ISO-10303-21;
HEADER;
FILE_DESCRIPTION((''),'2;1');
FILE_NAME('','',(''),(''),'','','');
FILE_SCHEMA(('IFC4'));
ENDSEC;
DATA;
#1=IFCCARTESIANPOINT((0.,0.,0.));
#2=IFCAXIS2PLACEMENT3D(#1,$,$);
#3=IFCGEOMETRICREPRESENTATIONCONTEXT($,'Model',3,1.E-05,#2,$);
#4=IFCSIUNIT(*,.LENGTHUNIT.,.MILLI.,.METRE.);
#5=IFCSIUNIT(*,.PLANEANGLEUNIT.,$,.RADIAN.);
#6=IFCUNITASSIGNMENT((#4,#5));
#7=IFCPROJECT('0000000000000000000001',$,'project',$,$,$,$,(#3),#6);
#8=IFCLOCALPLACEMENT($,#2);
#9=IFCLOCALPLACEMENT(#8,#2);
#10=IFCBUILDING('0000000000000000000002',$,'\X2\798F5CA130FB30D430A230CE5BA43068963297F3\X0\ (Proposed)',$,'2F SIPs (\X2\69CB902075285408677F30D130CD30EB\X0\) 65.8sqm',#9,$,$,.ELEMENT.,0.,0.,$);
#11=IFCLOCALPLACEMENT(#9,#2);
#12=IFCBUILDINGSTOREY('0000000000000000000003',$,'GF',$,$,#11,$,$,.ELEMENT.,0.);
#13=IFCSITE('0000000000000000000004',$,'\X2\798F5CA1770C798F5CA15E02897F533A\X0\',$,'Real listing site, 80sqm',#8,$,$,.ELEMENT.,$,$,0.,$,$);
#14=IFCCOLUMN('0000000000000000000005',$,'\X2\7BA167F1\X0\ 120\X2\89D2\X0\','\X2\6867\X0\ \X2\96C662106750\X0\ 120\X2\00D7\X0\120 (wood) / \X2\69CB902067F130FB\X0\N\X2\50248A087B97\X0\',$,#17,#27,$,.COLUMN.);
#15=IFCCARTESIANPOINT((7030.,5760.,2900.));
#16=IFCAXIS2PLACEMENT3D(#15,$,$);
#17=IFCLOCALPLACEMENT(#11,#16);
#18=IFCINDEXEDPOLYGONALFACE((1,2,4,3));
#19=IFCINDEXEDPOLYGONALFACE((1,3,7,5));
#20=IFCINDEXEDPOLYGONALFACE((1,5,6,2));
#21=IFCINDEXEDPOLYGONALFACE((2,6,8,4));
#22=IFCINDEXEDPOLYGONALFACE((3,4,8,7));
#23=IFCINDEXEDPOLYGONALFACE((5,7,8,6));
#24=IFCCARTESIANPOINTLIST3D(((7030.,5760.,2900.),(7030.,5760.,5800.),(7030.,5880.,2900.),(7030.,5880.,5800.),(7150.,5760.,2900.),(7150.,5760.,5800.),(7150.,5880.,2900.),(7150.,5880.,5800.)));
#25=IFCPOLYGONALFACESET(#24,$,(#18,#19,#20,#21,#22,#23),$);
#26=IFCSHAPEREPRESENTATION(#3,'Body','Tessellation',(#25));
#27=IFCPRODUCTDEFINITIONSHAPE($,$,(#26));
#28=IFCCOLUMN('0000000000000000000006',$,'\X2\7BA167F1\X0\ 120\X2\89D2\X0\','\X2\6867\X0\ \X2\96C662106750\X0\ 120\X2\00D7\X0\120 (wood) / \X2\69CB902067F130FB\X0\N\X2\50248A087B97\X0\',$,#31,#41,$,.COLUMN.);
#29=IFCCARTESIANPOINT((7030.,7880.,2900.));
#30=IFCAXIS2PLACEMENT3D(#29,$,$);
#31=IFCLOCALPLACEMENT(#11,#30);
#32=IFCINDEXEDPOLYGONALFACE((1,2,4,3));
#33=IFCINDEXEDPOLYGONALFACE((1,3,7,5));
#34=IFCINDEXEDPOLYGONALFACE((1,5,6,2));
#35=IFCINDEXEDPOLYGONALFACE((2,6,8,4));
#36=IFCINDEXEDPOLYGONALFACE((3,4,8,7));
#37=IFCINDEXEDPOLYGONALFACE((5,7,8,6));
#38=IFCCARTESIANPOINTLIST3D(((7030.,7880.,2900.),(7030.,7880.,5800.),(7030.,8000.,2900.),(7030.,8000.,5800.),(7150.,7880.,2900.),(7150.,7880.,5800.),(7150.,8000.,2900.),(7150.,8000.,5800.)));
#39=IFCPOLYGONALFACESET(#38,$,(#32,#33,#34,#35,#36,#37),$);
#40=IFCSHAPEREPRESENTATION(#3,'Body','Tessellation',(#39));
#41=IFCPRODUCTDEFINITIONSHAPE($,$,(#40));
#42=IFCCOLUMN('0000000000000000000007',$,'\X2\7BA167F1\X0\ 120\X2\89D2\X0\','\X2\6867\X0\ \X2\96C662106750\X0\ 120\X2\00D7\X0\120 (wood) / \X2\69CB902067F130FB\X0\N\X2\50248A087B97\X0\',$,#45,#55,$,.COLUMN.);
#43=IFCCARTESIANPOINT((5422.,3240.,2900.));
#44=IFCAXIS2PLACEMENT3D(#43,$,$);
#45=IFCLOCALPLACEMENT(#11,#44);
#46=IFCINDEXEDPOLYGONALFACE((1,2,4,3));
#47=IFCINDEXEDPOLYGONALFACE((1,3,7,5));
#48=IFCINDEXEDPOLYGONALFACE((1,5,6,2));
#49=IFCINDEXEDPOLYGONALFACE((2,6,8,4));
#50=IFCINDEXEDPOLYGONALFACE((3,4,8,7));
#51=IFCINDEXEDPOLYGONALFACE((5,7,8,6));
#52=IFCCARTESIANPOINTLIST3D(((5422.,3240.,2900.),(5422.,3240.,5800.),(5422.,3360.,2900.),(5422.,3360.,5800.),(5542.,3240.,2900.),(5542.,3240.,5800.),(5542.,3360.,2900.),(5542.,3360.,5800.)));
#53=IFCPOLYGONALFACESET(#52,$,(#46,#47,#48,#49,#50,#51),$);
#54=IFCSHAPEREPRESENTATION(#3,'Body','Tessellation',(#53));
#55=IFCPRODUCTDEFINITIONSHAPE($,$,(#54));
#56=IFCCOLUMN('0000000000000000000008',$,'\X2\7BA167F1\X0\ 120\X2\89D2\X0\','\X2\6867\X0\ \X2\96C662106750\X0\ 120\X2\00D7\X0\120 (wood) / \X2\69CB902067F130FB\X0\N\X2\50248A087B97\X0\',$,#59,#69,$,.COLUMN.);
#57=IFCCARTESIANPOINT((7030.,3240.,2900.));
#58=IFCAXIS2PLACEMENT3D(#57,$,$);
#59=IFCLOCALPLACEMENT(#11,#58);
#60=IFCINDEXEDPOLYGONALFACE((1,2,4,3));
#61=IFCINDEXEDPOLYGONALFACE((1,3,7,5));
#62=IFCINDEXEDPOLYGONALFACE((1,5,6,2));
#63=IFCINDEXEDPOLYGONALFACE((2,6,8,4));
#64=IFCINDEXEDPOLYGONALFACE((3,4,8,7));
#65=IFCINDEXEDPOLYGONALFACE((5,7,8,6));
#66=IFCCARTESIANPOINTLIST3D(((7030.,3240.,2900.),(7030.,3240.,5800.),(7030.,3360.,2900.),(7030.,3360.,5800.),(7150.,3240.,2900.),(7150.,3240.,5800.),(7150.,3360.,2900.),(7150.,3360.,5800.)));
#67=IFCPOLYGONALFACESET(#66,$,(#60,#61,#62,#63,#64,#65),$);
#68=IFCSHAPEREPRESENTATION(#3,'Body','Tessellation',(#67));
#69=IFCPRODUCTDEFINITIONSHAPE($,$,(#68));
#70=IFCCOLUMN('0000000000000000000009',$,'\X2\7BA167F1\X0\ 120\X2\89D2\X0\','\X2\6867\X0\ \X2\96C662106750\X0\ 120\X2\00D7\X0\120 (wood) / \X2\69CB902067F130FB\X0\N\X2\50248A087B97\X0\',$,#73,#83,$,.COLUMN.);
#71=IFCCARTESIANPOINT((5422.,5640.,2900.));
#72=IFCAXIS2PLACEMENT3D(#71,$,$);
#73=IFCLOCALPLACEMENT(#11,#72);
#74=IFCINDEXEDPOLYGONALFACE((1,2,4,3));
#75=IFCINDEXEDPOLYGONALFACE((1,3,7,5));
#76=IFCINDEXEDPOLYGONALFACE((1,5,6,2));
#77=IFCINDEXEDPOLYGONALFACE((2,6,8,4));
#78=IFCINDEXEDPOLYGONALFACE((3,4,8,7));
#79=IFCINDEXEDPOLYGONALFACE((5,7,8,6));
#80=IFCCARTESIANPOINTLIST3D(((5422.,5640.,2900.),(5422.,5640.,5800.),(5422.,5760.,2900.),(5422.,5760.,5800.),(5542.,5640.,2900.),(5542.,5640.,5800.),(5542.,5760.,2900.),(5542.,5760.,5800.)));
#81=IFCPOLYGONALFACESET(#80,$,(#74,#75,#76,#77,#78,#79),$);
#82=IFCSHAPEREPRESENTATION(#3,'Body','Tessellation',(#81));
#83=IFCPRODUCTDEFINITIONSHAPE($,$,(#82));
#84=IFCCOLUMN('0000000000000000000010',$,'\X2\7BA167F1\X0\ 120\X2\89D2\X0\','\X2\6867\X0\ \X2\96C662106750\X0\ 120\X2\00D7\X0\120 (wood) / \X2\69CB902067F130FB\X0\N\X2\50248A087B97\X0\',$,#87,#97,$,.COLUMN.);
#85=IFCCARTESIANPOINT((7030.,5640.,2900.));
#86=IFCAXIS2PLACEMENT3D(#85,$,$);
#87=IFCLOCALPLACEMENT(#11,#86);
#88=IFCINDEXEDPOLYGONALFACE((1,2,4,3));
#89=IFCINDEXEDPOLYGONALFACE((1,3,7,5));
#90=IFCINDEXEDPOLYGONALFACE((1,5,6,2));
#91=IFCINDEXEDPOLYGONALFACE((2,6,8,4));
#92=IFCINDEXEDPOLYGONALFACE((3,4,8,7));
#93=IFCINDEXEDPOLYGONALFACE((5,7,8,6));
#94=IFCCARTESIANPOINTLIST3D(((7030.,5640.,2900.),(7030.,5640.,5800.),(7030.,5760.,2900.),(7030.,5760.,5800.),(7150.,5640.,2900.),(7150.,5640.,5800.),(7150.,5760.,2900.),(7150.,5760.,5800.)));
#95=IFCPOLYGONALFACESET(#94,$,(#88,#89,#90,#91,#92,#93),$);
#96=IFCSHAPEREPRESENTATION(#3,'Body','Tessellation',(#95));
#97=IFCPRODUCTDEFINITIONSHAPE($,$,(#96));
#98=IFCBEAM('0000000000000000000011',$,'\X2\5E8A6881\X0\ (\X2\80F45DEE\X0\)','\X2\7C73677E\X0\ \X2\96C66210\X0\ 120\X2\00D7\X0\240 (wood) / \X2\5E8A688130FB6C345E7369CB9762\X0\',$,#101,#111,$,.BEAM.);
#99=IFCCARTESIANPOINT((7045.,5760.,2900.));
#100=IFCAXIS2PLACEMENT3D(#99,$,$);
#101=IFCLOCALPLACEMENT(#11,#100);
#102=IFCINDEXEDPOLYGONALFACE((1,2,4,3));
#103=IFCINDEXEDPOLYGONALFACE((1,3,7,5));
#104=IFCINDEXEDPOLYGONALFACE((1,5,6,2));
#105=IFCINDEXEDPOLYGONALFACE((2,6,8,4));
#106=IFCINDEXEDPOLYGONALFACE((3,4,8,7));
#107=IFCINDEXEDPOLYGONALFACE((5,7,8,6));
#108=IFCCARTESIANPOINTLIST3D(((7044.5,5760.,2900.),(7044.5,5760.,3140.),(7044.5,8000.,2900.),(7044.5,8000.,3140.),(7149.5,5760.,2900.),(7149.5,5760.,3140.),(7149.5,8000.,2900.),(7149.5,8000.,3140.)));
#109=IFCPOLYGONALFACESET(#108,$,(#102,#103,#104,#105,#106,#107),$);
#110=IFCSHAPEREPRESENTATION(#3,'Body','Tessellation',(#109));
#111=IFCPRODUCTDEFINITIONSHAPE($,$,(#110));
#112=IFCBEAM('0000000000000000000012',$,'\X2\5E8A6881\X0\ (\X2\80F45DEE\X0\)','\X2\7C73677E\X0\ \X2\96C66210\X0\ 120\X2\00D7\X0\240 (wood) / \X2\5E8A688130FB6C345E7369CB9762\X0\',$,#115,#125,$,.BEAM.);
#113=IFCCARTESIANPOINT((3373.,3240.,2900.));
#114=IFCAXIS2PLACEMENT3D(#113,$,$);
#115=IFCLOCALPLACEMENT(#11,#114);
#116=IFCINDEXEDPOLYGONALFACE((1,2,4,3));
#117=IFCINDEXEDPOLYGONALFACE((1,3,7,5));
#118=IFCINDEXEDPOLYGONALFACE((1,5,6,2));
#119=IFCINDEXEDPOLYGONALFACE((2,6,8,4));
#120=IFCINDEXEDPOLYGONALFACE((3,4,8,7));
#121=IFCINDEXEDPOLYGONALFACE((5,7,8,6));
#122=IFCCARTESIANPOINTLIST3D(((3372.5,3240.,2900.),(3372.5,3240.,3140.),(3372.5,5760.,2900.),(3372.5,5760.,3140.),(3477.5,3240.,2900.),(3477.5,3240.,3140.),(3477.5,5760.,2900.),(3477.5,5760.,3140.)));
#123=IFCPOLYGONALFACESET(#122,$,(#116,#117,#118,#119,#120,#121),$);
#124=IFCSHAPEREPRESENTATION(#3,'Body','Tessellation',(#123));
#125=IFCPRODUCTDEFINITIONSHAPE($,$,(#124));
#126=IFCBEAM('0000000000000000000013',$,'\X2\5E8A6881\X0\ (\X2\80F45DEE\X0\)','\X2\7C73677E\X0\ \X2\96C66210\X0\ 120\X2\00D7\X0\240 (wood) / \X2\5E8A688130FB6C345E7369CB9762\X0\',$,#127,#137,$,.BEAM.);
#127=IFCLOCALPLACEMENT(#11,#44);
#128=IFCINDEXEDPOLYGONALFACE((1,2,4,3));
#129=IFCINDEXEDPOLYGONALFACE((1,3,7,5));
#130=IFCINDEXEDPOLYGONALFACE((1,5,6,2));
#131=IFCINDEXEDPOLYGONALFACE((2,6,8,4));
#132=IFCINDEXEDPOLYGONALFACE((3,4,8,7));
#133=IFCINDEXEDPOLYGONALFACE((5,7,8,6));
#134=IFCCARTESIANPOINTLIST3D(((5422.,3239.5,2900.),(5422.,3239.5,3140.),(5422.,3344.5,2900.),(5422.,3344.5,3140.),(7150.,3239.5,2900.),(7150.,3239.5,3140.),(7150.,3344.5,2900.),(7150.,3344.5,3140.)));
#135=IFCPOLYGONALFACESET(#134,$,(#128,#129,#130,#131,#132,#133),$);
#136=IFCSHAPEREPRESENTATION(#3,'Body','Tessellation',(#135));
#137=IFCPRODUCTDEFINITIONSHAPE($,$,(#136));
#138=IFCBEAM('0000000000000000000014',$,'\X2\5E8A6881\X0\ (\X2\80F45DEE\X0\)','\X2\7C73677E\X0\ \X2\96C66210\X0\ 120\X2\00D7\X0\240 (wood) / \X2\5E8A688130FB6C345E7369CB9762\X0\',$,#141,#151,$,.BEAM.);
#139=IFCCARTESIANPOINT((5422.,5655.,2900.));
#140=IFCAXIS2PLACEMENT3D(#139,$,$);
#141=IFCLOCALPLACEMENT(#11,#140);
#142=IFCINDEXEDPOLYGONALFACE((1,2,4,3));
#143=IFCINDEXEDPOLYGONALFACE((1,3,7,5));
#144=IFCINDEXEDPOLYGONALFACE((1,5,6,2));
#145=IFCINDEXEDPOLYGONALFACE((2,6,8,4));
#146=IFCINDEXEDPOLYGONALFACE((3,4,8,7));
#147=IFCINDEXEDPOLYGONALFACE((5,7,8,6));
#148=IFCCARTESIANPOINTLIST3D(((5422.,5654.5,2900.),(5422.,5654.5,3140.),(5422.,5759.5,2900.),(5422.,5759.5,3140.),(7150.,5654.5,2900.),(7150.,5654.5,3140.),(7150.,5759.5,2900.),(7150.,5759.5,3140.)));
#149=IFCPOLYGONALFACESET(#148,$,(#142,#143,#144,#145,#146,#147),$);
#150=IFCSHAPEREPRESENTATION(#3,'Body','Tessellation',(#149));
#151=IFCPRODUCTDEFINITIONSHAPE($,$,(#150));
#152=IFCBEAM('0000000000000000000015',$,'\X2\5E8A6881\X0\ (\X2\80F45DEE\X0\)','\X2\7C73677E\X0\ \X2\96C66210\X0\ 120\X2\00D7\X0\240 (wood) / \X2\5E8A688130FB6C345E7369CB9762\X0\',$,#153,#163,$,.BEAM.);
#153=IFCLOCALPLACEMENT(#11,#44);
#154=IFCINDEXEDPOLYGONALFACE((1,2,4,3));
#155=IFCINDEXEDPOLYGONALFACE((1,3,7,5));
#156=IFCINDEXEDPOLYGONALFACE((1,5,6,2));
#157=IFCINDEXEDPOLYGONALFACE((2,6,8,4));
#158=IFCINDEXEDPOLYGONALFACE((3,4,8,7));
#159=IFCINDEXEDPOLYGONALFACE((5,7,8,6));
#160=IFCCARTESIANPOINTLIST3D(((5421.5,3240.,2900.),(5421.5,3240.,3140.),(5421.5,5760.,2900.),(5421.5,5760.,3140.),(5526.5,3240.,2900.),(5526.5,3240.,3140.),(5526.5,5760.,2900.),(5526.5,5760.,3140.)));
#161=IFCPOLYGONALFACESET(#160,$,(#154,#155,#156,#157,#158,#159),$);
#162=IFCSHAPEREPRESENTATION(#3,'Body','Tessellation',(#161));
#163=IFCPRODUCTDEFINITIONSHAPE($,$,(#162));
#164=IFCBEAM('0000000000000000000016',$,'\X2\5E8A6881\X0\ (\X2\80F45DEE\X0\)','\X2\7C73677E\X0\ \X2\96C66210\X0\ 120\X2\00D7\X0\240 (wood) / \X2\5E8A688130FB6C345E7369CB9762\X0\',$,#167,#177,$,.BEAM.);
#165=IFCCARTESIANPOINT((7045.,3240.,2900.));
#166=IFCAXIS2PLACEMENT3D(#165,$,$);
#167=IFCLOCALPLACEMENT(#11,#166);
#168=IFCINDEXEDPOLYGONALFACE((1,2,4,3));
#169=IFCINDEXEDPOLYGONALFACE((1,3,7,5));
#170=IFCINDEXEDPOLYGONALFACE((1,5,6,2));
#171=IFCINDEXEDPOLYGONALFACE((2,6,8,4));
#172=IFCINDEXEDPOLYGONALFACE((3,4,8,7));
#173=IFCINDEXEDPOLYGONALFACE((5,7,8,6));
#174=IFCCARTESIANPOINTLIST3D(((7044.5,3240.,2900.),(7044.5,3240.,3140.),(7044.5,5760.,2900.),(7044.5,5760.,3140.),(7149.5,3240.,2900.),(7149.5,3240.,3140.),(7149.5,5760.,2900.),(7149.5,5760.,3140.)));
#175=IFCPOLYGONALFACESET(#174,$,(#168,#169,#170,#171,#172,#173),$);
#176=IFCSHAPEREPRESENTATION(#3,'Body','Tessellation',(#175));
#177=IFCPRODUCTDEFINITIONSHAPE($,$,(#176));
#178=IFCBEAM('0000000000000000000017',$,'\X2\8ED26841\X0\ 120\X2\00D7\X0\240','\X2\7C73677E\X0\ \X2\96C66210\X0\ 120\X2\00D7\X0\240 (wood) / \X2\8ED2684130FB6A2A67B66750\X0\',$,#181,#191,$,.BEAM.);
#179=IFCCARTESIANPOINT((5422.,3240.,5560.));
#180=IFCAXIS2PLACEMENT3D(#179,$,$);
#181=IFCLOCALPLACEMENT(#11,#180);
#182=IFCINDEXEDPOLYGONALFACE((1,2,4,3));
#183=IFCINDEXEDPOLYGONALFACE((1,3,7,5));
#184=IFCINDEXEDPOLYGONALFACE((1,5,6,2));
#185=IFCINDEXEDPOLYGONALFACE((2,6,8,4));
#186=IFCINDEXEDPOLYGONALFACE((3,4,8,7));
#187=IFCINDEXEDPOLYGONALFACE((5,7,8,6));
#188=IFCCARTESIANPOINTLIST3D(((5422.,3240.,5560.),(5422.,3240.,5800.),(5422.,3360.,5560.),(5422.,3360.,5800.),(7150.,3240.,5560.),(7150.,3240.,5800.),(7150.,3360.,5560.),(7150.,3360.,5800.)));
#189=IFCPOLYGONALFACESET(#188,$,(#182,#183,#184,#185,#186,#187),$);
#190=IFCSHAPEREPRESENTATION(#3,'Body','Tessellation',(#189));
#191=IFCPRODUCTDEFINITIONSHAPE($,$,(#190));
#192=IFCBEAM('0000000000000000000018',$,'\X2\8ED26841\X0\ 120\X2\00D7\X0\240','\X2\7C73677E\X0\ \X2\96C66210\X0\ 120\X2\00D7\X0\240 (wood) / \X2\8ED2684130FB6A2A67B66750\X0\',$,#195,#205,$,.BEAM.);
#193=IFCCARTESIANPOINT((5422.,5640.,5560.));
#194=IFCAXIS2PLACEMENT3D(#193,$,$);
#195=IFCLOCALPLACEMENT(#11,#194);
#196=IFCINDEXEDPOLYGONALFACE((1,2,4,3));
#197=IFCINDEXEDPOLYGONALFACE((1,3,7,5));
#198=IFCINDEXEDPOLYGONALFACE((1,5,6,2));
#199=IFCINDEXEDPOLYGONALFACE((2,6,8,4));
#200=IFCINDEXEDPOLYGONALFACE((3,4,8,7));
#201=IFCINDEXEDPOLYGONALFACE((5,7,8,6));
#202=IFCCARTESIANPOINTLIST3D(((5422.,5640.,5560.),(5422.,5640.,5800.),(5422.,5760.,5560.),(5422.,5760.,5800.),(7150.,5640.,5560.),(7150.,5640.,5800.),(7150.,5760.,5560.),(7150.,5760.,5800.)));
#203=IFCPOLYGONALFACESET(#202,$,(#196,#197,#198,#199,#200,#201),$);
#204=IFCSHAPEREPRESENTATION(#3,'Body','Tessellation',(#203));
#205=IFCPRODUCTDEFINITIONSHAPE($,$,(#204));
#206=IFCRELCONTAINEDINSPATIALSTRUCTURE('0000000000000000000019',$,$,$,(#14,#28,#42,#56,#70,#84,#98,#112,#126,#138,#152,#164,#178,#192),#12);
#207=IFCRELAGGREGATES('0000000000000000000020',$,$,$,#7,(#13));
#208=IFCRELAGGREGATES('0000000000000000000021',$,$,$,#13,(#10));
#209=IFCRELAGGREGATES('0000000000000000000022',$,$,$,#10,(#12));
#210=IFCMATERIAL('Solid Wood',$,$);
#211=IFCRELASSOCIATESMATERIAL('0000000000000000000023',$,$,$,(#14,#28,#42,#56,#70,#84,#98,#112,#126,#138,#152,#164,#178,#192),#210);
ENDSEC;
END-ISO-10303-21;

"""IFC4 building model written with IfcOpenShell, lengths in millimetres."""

from ifc_helpers import new_model, si_unit, frame, frame_2d, origin, place, context, project, spatial, rectangle, extrude, material, element, save


model = new_model("IFC4")

# Units and contexts
model_context = context("Model", 3, precision=1e-05, world=origin())
ifc_project = project(units=[si_unit("LENGTHUNIT", "METRE", prefix="MILLI"), si_unit("PLANEANGLEUNIT", "RADIAN")], contexts=[model_context])

# Site, building, storey
site_placement = place(None, origin())
site = spatial("IfcSite", under=ifc_project, at=site_placement, Name="福岡県福岡市西区", ObjectType="Real listing site, 80sqm", CompositionType="ELEMENT", RefElevation=0.0)
building_placement = place(site_placement, origin())
building = spatial("IfcBuilding", under=site, at=building_placement, Name="福岡・ピアノ室と防音 (Proposed)", ObjectType="2F SIPs (構造用合板パネル) 65.8sqm", CompositionType="ELEMENT", ElevationOfRefHeight=0.0, ElevationOfTerrain=0.0)
storey_placement = place(building_placement, origin())
storey = spatial("IfcBuildingStorey", under=building, at=storey_placement, Name="GF", CompositionType="ELEMENT", Elevation=0.0)

# Columns
ifc_material_1 = material(Name="Solid Wood")
column_1_placement = place(storey_placement, frame((7030.0, 5760.0, 2900.0)))
element("IfcColumn", 1, at=column_1_placement, inside=storey, material=ifc_material_1, Name="管柱 120角", Description="桧 集成材 120×120 (wood) / 構造柱・N値計算", PredefinedType="COLUMN", context=model_context, shape_type="SweptSolid", body=[
    extrude(rectangle(XDim=120.0, YDim=120.0, at=frame_2d((60.0, 60.0))), frame((7030.0, 5760.0, 2900.0)), (0.0, 0.0, 1.0), 2900.0),
])
column_2_placement = place(storey_placement, frame((7030.0, 7880.0, 2900.0)))
element("IfcColumn", 2, at=column_2_placement, inside=storey, material=ifc_material_1, Name="管柱 120角", Description="桧 集成材 120×120 (wood) / 構造柱・N値計算", PredefinedType="COLUMN", context=model_context, shape_type="SweptSolid", body=[
    extrude(rectangle(XDim=120.0, YDim=120.0, at=frame_2d((60.0, 60.0))), frame((7030.0, 7880.0, 2900.0)), (0.0, 0.0, 1.0), 2900.0),
])
column_3_placement = place(storey_placement, frame((5422.0, 3240.0, 2900.0)))
element("IfcColumn", 3, at=column_3_placement, inside=storey, material=ifc_material_1, Name="管柱 120角", Description="桧 集成材 120×120 (wood) / 構造柱・N値計算", PredefinedType="COLUMN", context=model_context, shape_type="SweptSolid", body=[
    extrude(rectangle(XDim=120.0, YDim=120.0, at=frame_2d((60.0, 60.0))), frame((5422.0, 3240.0, 2900.0)), (0.0, 0.0, 1.0), 2900.0),
])
column_4_placement = place(storey_placement, frame((7030.0, 3240.0, 2900.0)))
element("IfcColumn", 4, at=column_4_placement, inside=storey, material=ifc_material_1, Name="管柱 120角", Description="桧 集成材 120×120 (wood) / 構造柱・N値計算", PredefinedType="COLUMN", context=model_context, shape_type="SweptSolid", body=[
    extrude(rectangle(XDim=120.0, YDim=120.0, at=frame_2d((60.0, 60.0))), frame((7030.0, 3240.0, 2900.0)), (0.0, 0.0, 1.0), 2900.0),
])
column_5_placement = place(storey_placement, frame((5422.0, 5640.0, 2900.0)))
element("IfcColumn", 5, at=column_5_placement, inside=storey, material=ifc_material_1, Name="管柱 120角", Description="桧 集成材 120×120 (wood) / 構造柱・N値計算", PredefinedType="COLUMN", context=model_context, shape_type="SweptSolid", body=[
    extrude(rectangle(XDim=120.0, YDim=120.0, at=frame_2d((60.0, 60.0))), frame((5422.0, 5640.0, 2900.0)), (0.0, 0.0, 1.0), 2900.0),
])
column_6_placement = place(storey_placement, frame((7030.0, 5640.0, 2900.0)))
element("IfcColumn", 6, at=column_6_placement, inside=storey, material=ifc_material_1, Name="管柱 120角", Description="桧 集成材 120×120 (wood) / 構造柱・N値計算", PredefinedType="COLUMN", context=model_context, shape_type="SweptSolid", body=[
    extrude(rectangle(XDim=120.0, YDim=120.0, at=frame_2d((60.0, 60.0))), frame((7030.0, 5640.0, 2900.0)), (0.0, 0.0, 1.0), 2900.0),
])

# Beams
beam_1_placement = place(storey_placement, frame((7045.0, 5760.0, 2900.0)))
element("IfcBeam", 7, at=beam_1_placement, inside=storey, material=ifc_material_1, Name="床梁 (胴差)", Description="米松 集成 120×240 (wood) / 床梁・水平構面", PredefinedType="BEAM", context=model_context, shape_type="SweptSolid", body=[
    extrude(rectangle(XDim=105.0, YDim=2240.0, at=frame_2d((52.0, 1120.0))), frame((7045.0, 5760.0, 2900.0)), (0.0, 0.0, 1.0), 240.0),
])
beam_2_placement = place(storey_placement, frame((3373.0, 3240.0, 2900.0)))
element("IfcBeam", 8, at=beam_2_placement, inside=storey, material=ifc_material_1, Name="床梁 (胴差)", Description="米松 集成 120×240 (wood) / 床梁・水平構面", PredefinedType="BEAM", context=model_context, shape_type="SweptSolid", body=[
    extrude(rectangle(XDim=105.0, YDim=2520.0, at=frame_2d((52.0, 1260.0))), frame((3373.0, 3240.0, 2900.0)), (0.0, 0.0, 1.0), 240.0),
])
beam_3_placement = place(storey_placement, frame((5422.0, 3240.0, 2900.0)))
element("IfcBeam", 9, at=beam_3_placement, inside=storey, material=ifc_material_1, Name="床梁 (胴差)", Description="米松 集成 120×240 (wood) / 床梁・水平構面", PredefinedType="BEAM", context=model_context, shape_type="SweptSolid", body=[
    extrude(rectangle(XDim=1728.0, YDim=105.0, at=frame_2d((864.0, 52.0))), frame((5422.0, 3240.0, 2900.0)), (0.0, 0.0, 1.0), 240.0),
])
beam_4_placement = place(storey_placement, frame((5422.0, 5655.0, 2900.0)))
element("IfcBeam", 10, at=beam_4_placement, inside=storey, material=ifc_material_1, Name="床梁 (胴差)", Description="米松 集成 120×240 (wood) / 床梁・水平構面", PredefinedType="BEAM", context=model_context, shape_type="SweptSolid", body=[
    extrude(rectangle(XDim=1728.0, YDim=105.0, at=frame_2d((864.0, 52.0))), frame((5422.0, 5655.0, 2900.0)), (0.0, 0.0, 1.0), 240.0),
])
beam_5_placement = place(storey_placement, frame((5422.0, 3240.0, 2900.0)))
element("IfcBeam", 11, at=beam_5_placement, inside=storey, material=ifc_material_1, Name="床梁 (胴差)", Description="米松 集成 120×240 (wood) / 床梁・水平構面", PredefinedType="BEAM", context=model_context, shape_type="SweptSolid", body=[
    extrude(rectangle(XDim=105.0, YDim=2520.0, at=frame_2d((52.0, 1260.0))), frame((5422.0, 3240.0, 2900.0)), (0.0, 0.0, 1.0), 240.0),
])
beam_6_placement = place(storey_placement, frame((7045.0, 3240.0, 2900.0)))
element("IfcBeam", 12, at=beam_6_placement, inside=storey, material=ifc_material_1, Name="床梁 (胴差)", Description="米松 集成 120×240 (wood) / 床梁・水平構面", PredefinedType="BEAM", context=model_context, shape_type="SweptSolid", body=[
    extrude(rectangle(XDim=105.0, YDim=2520.0, at=frame_2d((52.0, 1260.0))), frame((7045.0, 3240.0, 2900.0)), (0.0, 0.0, 1.0), 240.0),
])
beam_7_placement = place(storey_placement, frame((5422.0, 3240.0, 5560.0)))
element("IfcBeam", 13, at=beam_7_placement, inside=storey, material=ifc_material_1, Name="軒桁 120×240", Description="米松 集成 120×240 (wood) / 軒桁・横架材", PredefinedType="BEAM", context=model_context, shape_type="SweptSolid", body=[
    extrude(rectangle(XDim=1728.0, YDim=120.0, at=frame_2d((864.0, 60.0))), frame((5422.0, 3240.0, 5560.0)), (0.0, 0.0, 1.0), 240.0),
])
beam_8_placement = place(storey_placement, frame((5422.0, 5640.0, 5560.0)))
element("IfcBeam", 14, at=beam_8_placement, inside=storey, material=ifc_material_1, Name="軒桁 120×240", Description="米松 集成 120×240 (wood) / 軒桁・横架材", PredefinedType="BEAM", context=model_context, shape_type="SweptSolid", body=[
    extrude(rectangle(XDim=1728.0, YDim=120.0, at=frame_2d((864.0, 60.0))), frame((5422.0, 5640.0, 5560.0)), (0.0, 0.0, 1.0), 240.0),
])

save(model, "model.ifc")
